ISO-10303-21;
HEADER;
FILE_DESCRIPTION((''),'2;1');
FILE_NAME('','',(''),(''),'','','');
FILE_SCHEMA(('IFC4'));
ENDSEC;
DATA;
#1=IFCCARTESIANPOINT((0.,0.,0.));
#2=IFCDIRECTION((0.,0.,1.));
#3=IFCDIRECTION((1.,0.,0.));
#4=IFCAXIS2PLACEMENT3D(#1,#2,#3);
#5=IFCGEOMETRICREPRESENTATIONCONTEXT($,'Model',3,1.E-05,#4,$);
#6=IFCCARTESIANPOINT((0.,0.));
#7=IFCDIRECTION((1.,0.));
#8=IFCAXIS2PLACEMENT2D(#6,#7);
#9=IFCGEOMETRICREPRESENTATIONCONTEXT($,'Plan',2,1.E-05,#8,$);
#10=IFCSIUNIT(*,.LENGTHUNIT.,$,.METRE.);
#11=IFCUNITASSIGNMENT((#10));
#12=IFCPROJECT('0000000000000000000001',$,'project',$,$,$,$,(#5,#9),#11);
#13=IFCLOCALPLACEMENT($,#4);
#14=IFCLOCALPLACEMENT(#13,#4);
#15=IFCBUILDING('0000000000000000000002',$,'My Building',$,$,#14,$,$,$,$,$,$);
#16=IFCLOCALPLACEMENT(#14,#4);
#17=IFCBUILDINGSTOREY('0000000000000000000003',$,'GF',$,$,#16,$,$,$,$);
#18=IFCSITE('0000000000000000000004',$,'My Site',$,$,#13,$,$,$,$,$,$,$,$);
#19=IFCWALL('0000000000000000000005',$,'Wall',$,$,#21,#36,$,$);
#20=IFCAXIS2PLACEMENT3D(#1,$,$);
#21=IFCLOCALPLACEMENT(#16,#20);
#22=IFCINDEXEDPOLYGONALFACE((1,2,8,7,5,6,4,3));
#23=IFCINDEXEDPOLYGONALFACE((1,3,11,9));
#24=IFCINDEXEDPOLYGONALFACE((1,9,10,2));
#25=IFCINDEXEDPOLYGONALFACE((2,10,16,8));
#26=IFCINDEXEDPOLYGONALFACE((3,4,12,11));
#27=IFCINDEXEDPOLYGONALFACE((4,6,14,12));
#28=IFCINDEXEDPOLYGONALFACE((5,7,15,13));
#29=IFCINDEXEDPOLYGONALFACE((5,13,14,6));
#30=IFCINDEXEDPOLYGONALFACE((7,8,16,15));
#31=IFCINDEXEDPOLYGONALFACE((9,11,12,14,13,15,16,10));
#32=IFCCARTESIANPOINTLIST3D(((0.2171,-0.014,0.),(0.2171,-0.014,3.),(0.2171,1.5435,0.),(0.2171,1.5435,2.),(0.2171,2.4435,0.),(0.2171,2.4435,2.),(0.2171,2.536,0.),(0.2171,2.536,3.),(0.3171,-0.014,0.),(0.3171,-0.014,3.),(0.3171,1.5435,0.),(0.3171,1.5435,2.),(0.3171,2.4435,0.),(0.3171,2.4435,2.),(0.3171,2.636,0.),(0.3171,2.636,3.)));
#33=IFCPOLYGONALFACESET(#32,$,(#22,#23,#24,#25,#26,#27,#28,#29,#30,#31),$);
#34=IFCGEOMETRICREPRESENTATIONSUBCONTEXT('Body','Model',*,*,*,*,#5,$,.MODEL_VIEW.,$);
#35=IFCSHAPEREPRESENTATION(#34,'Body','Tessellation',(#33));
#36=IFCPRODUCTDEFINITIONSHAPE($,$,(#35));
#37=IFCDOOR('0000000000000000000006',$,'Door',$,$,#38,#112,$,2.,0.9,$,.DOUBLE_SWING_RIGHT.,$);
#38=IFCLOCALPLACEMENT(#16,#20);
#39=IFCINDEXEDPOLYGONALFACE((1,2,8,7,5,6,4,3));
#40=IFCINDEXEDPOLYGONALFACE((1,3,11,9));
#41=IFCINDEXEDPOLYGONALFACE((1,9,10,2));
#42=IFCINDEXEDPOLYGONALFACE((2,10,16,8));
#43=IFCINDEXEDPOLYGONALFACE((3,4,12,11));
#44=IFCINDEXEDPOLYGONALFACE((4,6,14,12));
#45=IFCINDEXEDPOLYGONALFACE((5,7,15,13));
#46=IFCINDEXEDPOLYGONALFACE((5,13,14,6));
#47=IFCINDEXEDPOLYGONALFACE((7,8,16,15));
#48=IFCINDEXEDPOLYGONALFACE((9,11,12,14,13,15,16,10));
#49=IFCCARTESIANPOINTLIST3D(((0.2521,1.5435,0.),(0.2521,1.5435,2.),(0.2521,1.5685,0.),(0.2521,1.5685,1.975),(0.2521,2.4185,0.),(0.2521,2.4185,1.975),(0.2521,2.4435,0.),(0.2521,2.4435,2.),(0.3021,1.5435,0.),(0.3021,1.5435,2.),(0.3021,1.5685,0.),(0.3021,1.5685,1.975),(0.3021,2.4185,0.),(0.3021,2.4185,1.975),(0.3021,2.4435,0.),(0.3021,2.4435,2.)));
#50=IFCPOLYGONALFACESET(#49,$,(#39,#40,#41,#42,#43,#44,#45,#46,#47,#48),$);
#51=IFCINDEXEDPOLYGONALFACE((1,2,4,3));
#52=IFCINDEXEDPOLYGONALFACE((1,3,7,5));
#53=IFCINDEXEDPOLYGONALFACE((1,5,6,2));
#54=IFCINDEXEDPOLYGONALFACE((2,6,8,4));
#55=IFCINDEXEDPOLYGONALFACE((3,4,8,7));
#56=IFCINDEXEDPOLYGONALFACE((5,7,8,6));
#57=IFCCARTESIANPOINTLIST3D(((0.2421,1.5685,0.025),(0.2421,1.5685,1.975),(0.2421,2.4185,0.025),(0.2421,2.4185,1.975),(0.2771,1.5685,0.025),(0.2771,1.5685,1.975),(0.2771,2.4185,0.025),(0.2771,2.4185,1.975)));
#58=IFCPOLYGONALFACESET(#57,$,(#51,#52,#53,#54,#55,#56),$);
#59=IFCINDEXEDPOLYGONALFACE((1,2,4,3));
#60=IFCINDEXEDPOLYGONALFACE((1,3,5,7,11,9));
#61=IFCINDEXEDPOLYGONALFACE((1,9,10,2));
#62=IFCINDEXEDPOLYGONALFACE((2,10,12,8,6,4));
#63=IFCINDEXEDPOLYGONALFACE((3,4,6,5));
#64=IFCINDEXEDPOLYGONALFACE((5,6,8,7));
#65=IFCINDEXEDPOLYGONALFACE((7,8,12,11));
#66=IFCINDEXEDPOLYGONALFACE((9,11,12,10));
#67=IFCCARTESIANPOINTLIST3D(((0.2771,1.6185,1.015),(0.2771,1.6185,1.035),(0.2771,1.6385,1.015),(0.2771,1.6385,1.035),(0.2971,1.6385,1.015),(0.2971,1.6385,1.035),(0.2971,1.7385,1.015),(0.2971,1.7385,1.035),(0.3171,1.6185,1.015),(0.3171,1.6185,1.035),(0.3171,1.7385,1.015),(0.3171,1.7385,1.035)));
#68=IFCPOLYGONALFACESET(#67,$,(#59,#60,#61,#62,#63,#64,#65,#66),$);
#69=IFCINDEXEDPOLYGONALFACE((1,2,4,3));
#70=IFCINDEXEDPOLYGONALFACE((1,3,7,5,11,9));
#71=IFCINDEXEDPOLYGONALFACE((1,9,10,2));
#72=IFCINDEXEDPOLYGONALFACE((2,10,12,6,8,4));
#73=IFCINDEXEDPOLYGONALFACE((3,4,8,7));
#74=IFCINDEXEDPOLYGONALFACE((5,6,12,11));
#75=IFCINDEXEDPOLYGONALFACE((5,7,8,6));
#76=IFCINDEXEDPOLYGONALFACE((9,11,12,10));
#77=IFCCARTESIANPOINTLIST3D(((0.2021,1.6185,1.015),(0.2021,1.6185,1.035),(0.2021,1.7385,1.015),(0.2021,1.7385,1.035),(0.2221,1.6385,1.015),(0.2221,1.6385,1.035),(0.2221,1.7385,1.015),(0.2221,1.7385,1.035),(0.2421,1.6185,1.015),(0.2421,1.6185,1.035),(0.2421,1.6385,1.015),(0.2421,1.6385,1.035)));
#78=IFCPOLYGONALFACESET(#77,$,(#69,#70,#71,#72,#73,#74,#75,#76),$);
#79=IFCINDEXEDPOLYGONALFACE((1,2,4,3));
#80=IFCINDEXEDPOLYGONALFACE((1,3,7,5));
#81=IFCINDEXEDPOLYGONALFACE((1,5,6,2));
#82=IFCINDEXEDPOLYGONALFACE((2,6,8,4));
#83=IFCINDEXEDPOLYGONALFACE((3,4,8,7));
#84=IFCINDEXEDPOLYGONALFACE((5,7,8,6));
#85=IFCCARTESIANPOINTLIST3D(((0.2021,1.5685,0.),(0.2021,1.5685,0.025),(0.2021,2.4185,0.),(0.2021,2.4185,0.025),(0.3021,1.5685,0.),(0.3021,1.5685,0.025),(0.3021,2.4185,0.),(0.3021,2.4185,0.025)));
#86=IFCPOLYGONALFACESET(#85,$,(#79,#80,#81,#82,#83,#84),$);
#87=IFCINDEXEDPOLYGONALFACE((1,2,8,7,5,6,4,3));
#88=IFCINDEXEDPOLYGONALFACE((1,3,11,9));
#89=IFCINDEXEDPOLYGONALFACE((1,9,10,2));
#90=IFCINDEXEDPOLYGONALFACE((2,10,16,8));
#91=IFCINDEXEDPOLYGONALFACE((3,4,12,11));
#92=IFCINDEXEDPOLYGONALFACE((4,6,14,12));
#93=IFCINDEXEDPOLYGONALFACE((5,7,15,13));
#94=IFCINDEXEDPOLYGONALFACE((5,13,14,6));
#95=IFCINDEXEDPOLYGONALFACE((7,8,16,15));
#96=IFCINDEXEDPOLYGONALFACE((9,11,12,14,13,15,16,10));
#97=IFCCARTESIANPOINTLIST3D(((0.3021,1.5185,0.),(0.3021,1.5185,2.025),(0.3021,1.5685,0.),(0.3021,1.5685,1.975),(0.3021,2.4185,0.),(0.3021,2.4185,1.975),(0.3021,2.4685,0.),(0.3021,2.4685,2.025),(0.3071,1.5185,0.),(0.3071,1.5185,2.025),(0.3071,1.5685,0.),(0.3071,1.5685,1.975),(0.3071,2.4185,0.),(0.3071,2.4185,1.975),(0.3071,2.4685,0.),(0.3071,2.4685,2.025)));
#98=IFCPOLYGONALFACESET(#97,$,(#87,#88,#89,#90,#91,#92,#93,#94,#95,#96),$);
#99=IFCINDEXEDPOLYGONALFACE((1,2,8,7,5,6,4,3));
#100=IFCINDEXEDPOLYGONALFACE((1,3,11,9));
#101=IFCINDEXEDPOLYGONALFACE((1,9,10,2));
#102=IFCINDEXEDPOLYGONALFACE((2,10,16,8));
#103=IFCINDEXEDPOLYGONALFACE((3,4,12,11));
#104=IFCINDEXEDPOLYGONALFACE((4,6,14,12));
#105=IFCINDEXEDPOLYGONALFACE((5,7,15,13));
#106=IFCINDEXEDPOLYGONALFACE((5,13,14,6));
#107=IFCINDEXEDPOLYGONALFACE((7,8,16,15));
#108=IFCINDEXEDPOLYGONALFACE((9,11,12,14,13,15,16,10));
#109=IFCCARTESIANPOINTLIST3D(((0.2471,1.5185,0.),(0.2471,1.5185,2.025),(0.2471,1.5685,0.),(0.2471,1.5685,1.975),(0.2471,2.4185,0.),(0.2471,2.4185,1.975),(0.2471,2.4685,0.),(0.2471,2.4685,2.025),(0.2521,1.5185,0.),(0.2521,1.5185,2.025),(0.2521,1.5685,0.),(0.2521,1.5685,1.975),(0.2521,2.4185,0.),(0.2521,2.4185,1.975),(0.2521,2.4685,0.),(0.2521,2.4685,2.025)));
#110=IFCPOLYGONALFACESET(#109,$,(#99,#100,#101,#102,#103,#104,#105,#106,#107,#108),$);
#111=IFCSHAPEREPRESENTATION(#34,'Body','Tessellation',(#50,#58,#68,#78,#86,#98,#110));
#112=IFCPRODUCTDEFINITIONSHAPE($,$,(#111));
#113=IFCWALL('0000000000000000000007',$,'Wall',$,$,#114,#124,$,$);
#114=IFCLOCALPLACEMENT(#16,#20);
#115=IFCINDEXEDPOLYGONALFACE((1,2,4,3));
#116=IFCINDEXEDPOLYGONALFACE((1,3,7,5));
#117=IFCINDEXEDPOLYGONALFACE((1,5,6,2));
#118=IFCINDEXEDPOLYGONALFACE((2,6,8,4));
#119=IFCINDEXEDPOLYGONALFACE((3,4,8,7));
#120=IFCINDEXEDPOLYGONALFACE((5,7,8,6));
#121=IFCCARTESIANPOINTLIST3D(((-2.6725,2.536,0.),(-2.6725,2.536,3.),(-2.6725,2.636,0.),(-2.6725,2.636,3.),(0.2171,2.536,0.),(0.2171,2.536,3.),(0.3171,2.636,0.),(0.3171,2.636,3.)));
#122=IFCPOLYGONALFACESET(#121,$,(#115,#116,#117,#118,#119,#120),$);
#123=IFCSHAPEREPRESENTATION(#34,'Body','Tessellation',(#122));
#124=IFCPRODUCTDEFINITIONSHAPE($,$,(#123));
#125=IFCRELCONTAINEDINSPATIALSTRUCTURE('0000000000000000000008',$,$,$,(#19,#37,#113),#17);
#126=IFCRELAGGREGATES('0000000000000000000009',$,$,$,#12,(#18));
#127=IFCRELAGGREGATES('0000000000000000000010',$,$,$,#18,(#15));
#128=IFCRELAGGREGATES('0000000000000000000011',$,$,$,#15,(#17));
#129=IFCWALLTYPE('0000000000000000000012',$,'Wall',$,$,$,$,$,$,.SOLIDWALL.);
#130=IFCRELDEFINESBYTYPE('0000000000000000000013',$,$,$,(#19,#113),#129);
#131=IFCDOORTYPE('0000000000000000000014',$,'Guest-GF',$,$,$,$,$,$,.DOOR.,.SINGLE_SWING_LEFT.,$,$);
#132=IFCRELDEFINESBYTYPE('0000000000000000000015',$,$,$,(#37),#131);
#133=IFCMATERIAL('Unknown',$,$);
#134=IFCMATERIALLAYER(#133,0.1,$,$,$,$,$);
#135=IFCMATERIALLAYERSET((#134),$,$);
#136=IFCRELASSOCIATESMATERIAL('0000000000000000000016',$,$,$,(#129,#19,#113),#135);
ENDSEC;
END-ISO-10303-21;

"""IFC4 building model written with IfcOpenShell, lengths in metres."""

from ifc_helpers import new_model, entity, si_unit, frame, origin_with_axes, origin_2d_with_axis, place, context, subcontext, project, spatial, line, indexed_curve, outline, extrude, shape, source, transform, mapped, material, layer, layer_set, layer_usage, type_object, type_shapes, element, fill, save


model = new_model("IFC4")

# Units and contexts
model_context = context("Model", 3, precision=1e-05, world=origin_with_axes())
plan_context = context("Plan", 2, precision=1e-05, world=origin_2d_with_axis())
body_context_1 = subcontext(model_context, "Body", "Model", "MODEL_VIEW")
body_context_2 = subcontext(plan_context, "Body", "Plan", "PLAN_VIEW")
ifc_project = project(units=[si_unit("LENGTHUNIT", "METRE")], contexts=[model_context, plan_context])

# Site, building, storey
site_placement = place(None, origin_with_axes())
site = spatial("IfcSite", under=ifc_project, at=site_placement, Name="My Site")
building_placement = place(site_placement, origin_with_axes())
building = spatial("IfcBuilding", under=site, at=building_placement, Name="My Building")
storey_placement = place(building_placement, origin_with_axes())
storey = spatial("IfcBuildingStorey", under=building, at=storey_placement, Name="GF")

# Shared definitions
ifc_material = material(Name="Unknown")

# Shared definitions
ifc_layer_1 = layer(ifc_material, 0.1)
ifc_layer_set_1 = layer_set([ifc_layer_1])
wall_type = type_object("IfcWallType", Name="Wall", PredefinedType="SOLIDWALL", material=ifc_layer_set_1)

# Wall, opening, door
ifc_layer_usage_1 = layer_usage(ifc_layer_set_1, "AXIS2", "POSITIVE", 0.0)
wall_1_placement = place(storey_placement, frame((0.3171, -0.014, 0.0), z_axis=(0.0, 0.0, 1.0), x_axis=(0.0, 1.0, 0.0)))
wall_1 = element("IfcWall", 1, at=wall_1_placement, inside=storey, type_object=wall_type, material=ifc_layer_usage_1, Name="Wall", context=body_context_1, shape_type="SweptSolid", body=[
    extrude(outline(indexed_curve([(0.0, 0.0), (0.0, 0.1), (2.55, 0.1), (2.65, 0.0)], segments=[line(1, 2, 3, 4, 1)])), origin_with_axes(), (0.0, 0.0, 1.0), 3.0),
])
shared_shape_1 = source(origin_with_axes(), body_context_1, "Body", "SweptSolid", [
    extrude(outline(indexed_curve([(0.0, 0.0), (0.9, 0.0), (0.9, 2.0), (0.0, 2.0)], segments=[line(1, 2, 3, 4, 1)])), frame((0.0, -0.6, 0.0), z_axis=(0.0, -1.0, 0.0), x_axis=(1.0, 0.0, 0.0)), (0.0, 0.0, -1.0), 1.2),
])
opening_1_placement = place(wall_1_placement, frame((1.5576, 0.015, 0.0), z_axis=(0.0, 0.0, 1.0), x_axis=(1.0, 0.0, 0.0)))
opening_1 = element("IfcOpeningElement", 2, at=opening_1_placement, cuts=wall_1, PredefinedType="OPENING", context=body_context_1, shape_type="MappedRepresentation", body=[
    mapped(shared_shape_1, transform((0.0, 0.0, 0.0), x_axis=(1.0, 0.0, 0.0), y_axis=(0.0, 1.0, 0.0), z_axis=(0.0, 0.0, 1.0), scale=1.0)),
])
door_type_1 = type_object("IfcDoorType", Name="Guest-GF", OperationType="SINGLE_SWING_LEFT", PredefinedType="DOOR")
shared_shape_2 = source(origin_with_axes(), body_context_1, "Body", "SweptSolid", [
    extrude(outline(indexed_curve([(0.0, 0.0), (0.0, 2.0), (0.9, 2.0), (0.9, 0.0), (0.875, 0.0), (0.875, 1.975), (0.025, 1.975), (0.025, 0.0)], segments=[line(1, 2, 3, 4, 5, 6, 7, 8, 1)])), frame((0.0, 0.0, 0.0), z_axis=(0.0, -1.0, 0.0), x_axis=(1.0, 0.0, 0.0)), (0.0, 0.0, -1.0), 0.05),
    extrude(outline(indexed_curve([(0.0, 0.0), (0.85, 0.0), (0.85, 0.035), (0.0, 0.035)], segments=[line(1, 2, 3, 4, 1)])), frame((0.025, 0.025, 0.025), z_axis=(0.0, 0.0, 1.0), x_axis=(1.0, 0.0, 0.0)), (0.0, 0.0, 1.0), 1.95),
    extrude(outline(indexed_curve([(0.0, 0.0), (0.0, -0.04), (0.12, -0.04), (0.12, -0.02), (0.02, -0.02), (0.02, 0.0)], segments=[line(1, 2, 3, 4, 5, 6, 1)])), frame((0.075, 0.025, 1.015), z_axis=(0.0, 0.0, 1.0), x_axis=(1.0, 0.0, 0.0)), (0.0, 0.0, 1.0), 0.02),
    extrude(outline(indexed_curve([(0.0, 0.0), (0.0, 0.04), (0.12, 0.04), (0.12, 0.02), (0.02, 0.02), (0.02, 0.0)], segments=[line(1, 2, 3, 4, 5, 6, 1)])), frame((0.075, 0.06, 1.015), z_axis=(0.0, 0.0, 1.0), x_axis=(1.0, 0.0, 0.0)), (0.0, 0.0, 1.0), 0.02),
    extrude(outline(indexed_curve([(0.0, 0.0), (0.85, 0.0), (0.85, 0.1), (0.0, 0.1)], segments=[line(1, 2, 3, 4, 1)])), frame((0.025, 0.0, 0.0), z_axis=(0.0, 0.0, 1.0), x_axis=(1.0, 0.0, 0.0)), (0.0, 0.0, 1.0), 0.025),
    extrude(outline(indexed_curve([(0.0, 0.0), (0.0, 2.025), (0.95, 2.025), (0.95, 0.0), (0.9, 0.0), (0.9, 1.975), (0.05, 1.975), (0.05, 0.0)], segments=[line(1, 2, 3, 4, 5, 6, 7, 8, 1)])), frame((-0.025, -0.005, 0.0), z_axis=(0.0, -1.0, 0.0), x_axis=(1.0, 0.0, 0.0)), (0.0, 0.0, -1.0), 0.005),
    extrude(outline(indexed_curve([(0.0, 0.0), (0.0, 2.025), (0.95, 2.025), (0.95, 0.0), (0.9, 0.0), (0.9, 1.975), (0.05, 1.975), (0.05, 0.0)], segments=[line(1, 2, 3, 4, 5, 6, 7, 8, 1)])), frame((-0.025, 0.05, 0.0), z_axis=(0.0, -1.0, 0.0), x_axis=(1.0, 0.0, 0.0)), (0.0, 0.0, -1.0), 0.005),
])
shared_shape_3 = source(origin_with_axes(), body_context_2, "Body", "Curve2D", [
    entity("IfcIndexedPolyCurve", entity("IfcCartesianPointList2D", [[0.0, 0.0], [0.025, 0.0], [0.025, 0.05], [0.0, 0.05]]), [entity("IfcLineIndex", [1, 2, 3, 4, 1])]),
    entity("IfcIndexedPolyCurve", entity("IfcCartesianPointList2D", [[0.9, 0.0], [0.875, 0.0], [0.875, 0.05], [0.9, 0.05]]), [entity("IfcLineIndex", [1, 2, 3, 4, 1])]),
    entity("IfcIndexedPolyCurve", entity("IfcCartesianPointList2D", [[0.875, 0.05], [0.875, -0.8], [0.84, -0.8]])),
    entity("IfcTrimmedCurve", entity("IfcEllipse", entity("IfcAxis2Placement2D", entity("IfcCartesianPoint", [0.84, 0.05]), entity("IfcDirection", [1.0, 0.0])), 0.815, 0.85), [entity("IfcCartesianPoint", [0.84, 0.9])], [entity("IfcCartesianPoint", [0.84, -0.8])], True, "CARTESIAN"),
    entity("IfcIndexedPolyCurve", entity("IfcCartesianPointList2D", [[0.875, 0.05], [0.84, 0.05], [0.84, 0.9], [0.875, 0.9]]), [entity("IfcLineIndex", [1, 2, 3, 4, 1])]),
])
type_shapes(door_type_1, [shared_shape_2, shared_shape_3])
door_1_placement = place(opening_1_placement, frame((0.0, 0.0, 0.0), z_axis=(0.0, 0.0, 1.0), x_axis=(1.0, 0.0, 0.0)))
door_1 = element("IfcDoor", 3, at=door_1_placement, inside=storey, type_object=door_type_1, Name="Door", OperationType="DOUBLE_SWING_RIGHT", OverallHeight=2.0, OverallWidth=0.9, shapes=[
    shape(body_context_1, "Body", "MappedRepresentation", [mapped(shared_shape_2, transform((0.0, 0.0, 0.0), x_axis=(1.0, 0.0, 0.0), y_axis=(0.0, 1.0, 0.0), z_axis=(0.0, 0.0, 1.0), scale=1.0))]),
    shape(body_context_2, "Body", "MappedRepresentation", [mapped(shared_shape_3, transform((0.0, 0.0, 0.0), x_axis=(1.0, 0.0, 0.0), y_axis=(0.0, 1.0, 0.0), z_axis=(0.0, 0.0, 1.0), scale=1.0))]),
])
fill(opening_1, door_1)

# Wall
ifc_layer_usage_2 = layer_usage(ifc_layer_set_1, "AXIS2", "POSITIVE", 0.0)
wall_2_placement = place(storey_placement, frame((0.3171, 2.636, 0.0), z_axis=(0.0, 0.0, 1.0), x_axis=(-1.0, 0.0, 0.0)))
element("IfcWall", 4, at=wall_2_placement, inside=storey, type_object=wall_type, material=ifc_layer_usage_2, Name="Wall", context=body_context_1, shape_type="SweptSolid", body=[
    extrude(outline(indexed_curve([(0.0, 0.0), (0.1, 0.1), (2.9896, 0.1), (2.9896, 0.0)], segments=[line(1, 2, 3, 4, 1)])), origin_with_axes(), (0.0, 0.0, 1.0), 3.0),
])

save(model, "model.ifc")
